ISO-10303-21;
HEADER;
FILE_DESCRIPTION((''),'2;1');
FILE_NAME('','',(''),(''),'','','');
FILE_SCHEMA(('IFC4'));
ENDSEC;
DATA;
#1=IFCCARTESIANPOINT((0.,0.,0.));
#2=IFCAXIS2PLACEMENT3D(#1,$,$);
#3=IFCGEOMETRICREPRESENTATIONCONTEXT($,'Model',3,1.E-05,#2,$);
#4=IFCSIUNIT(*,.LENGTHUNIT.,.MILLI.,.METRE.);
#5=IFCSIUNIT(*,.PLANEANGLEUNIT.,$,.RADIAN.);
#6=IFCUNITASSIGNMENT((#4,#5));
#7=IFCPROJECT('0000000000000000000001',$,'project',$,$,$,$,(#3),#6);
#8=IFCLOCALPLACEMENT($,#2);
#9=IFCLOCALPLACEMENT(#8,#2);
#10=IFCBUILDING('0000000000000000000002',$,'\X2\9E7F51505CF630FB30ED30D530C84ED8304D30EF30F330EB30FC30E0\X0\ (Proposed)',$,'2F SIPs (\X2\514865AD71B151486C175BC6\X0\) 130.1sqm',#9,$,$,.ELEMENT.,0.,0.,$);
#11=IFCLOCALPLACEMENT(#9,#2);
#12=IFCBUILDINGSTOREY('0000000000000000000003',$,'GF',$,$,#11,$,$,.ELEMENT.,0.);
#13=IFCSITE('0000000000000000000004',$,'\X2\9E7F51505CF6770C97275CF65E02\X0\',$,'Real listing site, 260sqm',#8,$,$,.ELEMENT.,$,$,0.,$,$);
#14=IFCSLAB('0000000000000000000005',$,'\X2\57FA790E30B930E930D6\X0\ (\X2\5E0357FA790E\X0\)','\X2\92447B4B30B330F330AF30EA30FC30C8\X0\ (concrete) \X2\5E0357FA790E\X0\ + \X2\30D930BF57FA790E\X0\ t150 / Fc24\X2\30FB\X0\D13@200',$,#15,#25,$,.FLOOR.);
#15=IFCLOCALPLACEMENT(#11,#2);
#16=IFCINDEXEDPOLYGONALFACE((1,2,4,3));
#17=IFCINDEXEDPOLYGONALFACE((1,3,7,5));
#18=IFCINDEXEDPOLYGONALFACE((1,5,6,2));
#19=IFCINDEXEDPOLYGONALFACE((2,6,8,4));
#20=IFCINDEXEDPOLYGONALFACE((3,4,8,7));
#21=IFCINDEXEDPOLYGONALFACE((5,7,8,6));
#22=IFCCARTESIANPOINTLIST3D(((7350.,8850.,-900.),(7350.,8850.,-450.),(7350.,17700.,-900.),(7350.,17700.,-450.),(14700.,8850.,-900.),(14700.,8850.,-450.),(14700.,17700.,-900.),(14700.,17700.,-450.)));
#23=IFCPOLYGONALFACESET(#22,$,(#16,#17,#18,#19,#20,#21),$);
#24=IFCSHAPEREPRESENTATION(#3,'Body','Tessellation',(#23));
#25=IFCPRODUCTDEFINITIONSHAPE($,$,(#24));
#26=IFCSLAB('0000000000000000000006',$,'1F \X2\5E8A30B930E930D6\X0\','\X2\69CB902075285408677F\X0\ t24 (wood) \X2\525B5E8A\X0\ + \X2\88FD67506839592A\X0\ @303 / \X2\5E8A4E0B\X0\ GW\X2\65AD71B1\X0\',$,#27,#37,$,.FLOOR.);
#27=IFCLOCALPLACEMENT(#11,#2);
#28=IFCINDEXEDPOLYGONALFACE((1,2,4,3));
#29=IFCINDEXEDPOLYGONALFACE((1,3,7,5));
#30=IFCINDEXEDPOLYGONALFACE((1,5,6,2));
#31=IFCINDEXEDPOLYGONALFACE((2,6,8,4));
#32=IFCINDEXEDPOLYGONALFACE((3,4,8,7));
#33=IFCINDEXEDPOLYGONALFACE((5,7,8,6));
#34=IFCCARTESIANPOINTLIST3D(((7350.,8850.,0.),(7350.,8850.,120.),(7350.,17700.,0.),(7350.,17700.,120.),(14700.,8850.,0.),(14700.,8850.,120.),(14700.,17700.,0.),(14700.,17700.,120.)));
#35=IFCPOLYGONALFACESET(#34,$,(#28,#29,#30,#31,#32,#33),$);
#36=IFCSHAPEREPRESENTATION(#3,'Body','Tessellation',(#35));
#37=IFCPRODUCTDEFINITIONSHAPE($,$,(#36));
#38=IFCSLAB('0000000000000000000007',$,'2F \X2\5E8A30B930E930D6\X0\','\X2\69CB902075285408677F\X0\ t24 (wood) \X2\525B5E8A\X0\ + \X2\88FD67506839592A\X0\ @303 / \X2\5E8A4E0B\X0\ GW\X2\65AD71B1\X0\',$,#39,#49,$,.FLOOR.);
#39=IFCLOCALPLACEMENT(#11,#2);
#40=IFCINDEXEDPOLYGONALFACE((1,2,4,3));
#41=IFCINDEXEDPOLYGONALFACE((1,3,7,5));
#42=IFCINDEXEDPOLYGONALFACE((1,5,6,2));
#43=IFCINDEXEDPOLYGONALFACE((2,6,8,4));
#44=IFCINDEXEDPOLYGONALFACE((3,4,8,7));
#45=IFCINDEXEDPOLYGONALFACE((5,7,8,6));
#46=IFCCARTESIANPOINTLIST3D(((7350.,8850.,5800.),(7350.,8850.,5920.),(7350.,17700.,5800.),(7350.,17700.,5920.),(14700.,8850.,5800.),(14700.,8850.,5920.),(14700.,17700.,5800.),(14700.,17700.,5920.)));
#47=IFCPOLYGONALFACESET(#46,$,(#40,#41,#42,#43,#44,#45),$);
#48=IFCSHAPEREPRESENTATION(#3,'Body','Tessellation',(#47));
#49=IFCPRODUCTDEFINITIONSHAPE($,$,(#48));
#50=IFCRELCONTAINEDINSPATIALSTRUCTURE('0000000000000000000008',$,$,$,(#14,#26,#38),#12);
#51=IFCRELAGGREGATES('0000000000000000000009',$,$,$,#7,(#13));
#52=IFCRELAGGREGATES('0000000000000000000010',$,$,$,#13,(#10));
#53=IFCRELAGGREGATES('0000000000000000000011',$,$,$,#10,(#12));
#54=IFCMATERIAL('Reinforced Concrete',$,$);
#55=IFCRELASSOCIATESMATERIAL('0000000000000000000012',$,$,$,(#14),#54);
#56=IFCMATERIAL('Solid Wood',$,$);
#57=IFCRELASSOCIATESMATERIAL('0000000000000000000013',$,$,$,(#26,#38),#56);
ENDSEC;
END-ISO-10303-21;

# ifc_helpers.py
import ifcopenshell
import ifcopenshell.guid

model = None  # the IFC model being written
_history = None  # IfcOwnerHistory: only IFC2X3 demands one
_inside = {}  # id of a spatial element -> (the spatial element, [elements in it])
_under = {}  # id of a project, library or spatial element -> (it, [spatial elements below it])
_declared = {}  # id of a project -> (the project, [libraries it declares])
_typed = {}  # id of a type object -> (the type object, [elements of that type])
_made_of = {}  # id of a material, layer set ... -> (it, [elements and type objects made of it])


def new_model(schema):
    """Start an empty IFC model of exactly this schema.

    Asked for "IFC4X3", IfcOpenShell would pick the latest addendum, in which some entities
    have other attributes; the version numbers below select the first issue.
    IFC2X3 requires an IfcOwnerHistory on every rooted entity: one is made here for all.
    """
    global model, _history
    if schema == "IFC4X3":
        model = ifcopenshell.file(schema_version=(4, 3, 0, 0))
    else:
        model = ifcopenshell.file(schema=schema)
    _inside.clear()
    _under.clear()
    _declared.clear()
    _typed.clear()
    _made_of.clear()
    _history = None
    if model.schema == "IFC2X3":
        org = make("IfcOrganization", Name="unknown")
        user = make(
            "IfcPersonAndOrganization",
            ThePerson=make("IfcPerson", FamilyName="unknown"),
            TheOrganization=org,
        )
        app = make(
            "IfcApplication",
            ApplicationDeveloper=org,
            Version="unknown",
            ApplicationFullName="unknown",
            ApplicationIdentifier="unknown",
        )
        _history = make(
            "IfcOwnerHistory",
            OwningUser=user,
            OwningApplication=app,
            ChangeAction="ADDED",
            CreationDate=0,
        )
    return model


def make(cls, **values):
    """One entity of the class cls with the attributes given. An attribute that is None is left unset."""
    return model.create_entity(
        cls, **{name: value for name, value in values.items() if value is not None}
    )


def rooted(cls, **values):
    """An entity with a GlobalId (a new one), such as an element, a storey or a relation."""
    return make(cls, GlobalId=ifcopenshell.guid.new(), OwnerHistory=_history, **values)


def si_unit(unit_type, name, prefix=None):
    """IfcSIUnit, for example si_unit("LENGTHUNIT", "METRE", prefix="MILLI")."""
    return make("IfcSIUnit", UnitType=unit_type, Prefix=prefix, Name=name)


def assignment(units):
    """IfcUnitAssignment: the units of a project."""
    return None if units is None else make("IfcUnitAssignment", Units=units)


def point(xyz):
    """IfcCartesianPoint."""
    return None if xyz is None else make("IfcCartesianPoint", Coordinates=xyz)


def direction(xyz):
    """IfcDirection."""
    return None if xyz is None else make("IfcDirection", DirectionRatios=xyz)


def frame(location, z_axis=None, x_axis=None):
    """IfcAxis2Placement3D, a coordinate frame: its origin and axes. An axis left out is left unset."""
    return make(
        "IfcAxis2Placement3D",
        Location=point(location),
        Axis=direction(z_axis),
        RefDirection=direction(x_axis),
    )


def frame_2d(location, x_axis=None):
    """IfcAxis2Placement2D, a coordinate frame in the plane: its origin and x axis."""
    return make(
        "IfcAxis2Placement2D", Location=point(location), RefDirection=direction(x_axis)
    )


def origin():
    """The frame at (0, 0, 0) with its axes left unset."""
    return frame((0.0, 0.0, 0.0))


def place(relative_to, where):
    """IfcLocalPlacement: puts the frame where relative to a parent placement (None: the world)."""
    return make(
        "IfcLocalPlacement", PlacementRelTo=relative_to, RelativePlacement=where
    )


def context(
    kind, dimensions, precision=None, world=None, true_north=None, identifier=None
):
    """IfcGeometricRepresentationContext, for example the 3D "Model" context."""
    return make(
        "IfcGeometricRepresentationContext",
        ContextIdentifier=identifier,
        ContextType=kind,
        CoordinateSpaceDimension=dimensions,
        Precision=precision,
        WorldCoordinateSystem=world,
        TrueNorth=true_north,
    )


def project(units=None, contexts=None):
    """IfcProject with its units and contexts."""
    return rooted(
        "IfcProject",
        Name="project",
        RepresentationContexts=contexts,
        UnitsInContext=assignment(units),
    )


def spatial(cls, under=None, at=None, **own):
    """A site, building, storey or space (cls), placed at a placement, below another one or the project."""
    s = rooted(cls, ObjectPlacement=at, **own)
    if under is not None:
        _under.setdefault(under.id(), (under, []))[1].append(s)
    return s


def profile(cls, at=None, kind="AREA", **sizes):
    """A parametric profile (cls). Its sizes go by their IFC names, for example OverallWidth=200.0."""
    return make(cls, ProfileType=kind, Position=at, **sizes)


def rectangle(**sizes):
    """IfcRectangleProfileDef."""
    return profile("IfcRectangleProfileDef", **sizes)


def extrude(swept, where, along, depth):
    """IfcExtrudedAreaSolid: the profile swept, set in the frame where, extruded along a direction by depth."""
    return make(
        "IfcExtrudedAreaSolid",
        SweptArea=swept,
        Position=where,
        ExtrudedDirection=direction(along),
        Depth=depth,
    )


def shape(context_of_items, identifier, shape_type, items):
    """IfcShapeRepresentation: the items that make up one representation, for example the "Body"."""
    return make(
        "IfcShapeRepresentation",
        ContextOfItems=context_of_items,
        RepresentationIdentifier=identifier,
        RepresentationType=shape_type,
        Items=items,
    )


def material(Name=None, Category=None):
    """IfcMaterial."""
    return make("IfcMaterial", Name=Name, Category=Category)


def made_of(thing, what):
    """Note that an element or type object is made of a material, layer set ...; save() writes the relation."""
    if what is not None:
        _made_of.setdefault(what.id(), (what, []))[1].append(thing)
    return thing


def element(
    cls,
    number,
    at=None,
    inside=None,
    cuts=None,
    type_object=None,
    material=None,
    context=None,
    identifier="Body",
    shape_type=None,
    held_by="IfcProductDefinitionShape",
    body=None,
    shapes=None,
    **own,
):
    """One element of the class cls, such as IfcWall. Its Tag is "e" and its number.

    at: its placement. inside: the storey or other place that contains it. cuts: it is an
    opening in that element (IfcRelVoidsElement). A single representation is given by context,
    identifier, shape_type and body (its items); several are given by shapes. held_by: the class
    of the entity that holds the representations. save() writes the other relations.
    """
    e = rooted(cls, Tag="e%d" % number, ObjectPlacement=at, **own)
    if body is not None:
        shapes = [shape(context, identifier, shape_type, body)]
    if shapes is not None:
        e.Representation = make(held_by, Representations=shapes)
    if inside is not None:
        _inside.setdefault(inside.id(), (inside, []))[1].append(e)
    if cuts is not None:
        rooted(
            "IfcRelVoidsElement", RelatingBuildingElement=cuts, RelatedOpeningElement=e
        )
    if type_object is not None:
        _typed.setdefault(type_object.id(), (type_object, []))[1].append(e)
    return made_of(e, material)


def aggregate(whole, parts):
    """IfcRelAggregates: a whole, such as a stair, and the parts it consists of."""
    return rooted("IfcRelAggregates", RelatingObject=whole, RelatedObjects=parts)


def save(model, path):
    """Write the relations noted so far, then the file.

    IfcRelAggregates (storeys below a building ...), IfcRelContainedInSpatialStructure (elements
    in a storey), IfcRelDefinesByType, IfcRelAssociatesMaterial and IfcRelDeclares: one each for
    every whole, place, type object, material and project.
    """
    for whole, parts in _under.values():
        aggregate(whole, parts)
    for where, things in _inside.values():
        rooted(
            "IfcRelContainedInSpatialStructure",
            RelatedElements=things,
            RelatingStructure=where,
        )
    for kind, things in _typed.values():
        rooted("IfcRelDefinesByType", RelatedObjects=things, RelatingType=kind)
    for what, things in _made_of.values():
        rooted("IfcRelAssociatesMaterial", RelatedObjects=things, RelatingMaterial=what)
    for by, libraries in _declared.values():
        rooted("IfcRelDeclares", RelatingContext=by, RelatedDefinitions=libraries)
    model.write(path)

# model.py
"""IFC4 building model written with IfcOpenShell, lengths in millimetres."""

from ifc_helpers import new_model, si_unit, frame, frame_2d, origin, place, context, project, spatial, rectangle, extrude, material, element, save


model = new_model("IFC4")

# Units and contexts
model_context = context("Model", 3, precision=1e-05, world=origin())
ifc_project = project(units=[si_unit("LENGTHUNIT", "METRE", prefix="MILLI"), si_unit("PLANEANGLEUNIT", "RADIAN")], contexts=[model_context])

# Site, building, storey
site_placement = place(None, origin())
site = spatial("IfcSite", under=ifc_project, at=site_placement, Name="鹿児島県霧島市", ObjectType="Real listing site, 260sqm", CompositionType="ELEMENT", RefElevation=0.0)
building_placement = place(site_placement, origin())
building = spatial("IfcBuilding", under=site, at=building_placement, Name="鹿児島・ロフト付きワンルーム (Proposed)", ObjectType="2F SIPs (先断熱先気密) 130.1sqm", CompositionType="ELEMENT", ElevationOfRefHeight=0.0, ElevationOfTerrain=0.0)
storey_placement = place(building_placement, origin())
storey = spatial("IfcBuildingStorey", under=building, at=storey_placement, Name="GF", CompositionType="ELEMENT", Elevation=0.0)

# Shared definitions
ifc_material_1 = material(Name="Solid Wood")

# Slabs
ifc_material_2 = material(Name="Reinforced Concrete")
slab_1_placement = place(storey_placement, frame((3675.0, 4425.0, -450.0)))
element("IfcSlab", 1, at=slab_1_placement, inside=storey, material=ifc_material_2, Name="基礎スラブ (布基礎)", Description="鉄筋コンクリート (concrete) 布基礎 + ベタ基礎 t150 / Fc24・D13@200", PredefinedType="FLOOR", context=model_context, shape_type="SweptSolid", body=[
    extrude(rectangle(XDim=7350.0, YDim=8850.0, at=frame_2d((3675.0, 4425.0))), frame((3675.0, 4425.0, -450.0)), (0.0, 0.0, 1.0), 450.0),
])
slab_2_placement = place(storey_placement, frame((3675.0, 4425.0, 0.0)))
element("IfcSlab", 2, at=slab_2_placement, inside=storey, material=ifc_material_1, Name="1F 床スラブ", Description="構造用合板 t24 (wood) 剛床 + 製材根太 @303 / 床下 GW断熱", PredefinedType="FLOOR", context=model_context, shape_type="SweptSolid", body=[
    extrude(rectangle(XDim=7350.0, YDim=8850.0, at=frame_2d((3675.0, 4425.0))), frame((3675.0, 4425.0, 0.0)), (0.0, 0.0, 1.0), 120.0),
])
slab_3_placement = place(storey_placement, frame((3675.0, 4425.0, 2900.0)))
element("IfcSlab", 3, at=slab_3_placement, inside=storey, material=ifc_material_1, Name="2F 床スラブ", Description="構造用合板 t24 (wood) 剛床 + 製材根太 @303 / 床下 GW断熱", PredefinedType="FLOOR", context=model_context, shape_type="SweptSolid", body=[
    extrude(rectangle(XDim=7350.0, YDim=8850.0, at=frame_2d((3675.0, 4425.0))), frame((3675.0, 4425.0, 2900.0)), (0.0, 0.0, 1.0), 120.0),
])

save(model, "model.ifc")
